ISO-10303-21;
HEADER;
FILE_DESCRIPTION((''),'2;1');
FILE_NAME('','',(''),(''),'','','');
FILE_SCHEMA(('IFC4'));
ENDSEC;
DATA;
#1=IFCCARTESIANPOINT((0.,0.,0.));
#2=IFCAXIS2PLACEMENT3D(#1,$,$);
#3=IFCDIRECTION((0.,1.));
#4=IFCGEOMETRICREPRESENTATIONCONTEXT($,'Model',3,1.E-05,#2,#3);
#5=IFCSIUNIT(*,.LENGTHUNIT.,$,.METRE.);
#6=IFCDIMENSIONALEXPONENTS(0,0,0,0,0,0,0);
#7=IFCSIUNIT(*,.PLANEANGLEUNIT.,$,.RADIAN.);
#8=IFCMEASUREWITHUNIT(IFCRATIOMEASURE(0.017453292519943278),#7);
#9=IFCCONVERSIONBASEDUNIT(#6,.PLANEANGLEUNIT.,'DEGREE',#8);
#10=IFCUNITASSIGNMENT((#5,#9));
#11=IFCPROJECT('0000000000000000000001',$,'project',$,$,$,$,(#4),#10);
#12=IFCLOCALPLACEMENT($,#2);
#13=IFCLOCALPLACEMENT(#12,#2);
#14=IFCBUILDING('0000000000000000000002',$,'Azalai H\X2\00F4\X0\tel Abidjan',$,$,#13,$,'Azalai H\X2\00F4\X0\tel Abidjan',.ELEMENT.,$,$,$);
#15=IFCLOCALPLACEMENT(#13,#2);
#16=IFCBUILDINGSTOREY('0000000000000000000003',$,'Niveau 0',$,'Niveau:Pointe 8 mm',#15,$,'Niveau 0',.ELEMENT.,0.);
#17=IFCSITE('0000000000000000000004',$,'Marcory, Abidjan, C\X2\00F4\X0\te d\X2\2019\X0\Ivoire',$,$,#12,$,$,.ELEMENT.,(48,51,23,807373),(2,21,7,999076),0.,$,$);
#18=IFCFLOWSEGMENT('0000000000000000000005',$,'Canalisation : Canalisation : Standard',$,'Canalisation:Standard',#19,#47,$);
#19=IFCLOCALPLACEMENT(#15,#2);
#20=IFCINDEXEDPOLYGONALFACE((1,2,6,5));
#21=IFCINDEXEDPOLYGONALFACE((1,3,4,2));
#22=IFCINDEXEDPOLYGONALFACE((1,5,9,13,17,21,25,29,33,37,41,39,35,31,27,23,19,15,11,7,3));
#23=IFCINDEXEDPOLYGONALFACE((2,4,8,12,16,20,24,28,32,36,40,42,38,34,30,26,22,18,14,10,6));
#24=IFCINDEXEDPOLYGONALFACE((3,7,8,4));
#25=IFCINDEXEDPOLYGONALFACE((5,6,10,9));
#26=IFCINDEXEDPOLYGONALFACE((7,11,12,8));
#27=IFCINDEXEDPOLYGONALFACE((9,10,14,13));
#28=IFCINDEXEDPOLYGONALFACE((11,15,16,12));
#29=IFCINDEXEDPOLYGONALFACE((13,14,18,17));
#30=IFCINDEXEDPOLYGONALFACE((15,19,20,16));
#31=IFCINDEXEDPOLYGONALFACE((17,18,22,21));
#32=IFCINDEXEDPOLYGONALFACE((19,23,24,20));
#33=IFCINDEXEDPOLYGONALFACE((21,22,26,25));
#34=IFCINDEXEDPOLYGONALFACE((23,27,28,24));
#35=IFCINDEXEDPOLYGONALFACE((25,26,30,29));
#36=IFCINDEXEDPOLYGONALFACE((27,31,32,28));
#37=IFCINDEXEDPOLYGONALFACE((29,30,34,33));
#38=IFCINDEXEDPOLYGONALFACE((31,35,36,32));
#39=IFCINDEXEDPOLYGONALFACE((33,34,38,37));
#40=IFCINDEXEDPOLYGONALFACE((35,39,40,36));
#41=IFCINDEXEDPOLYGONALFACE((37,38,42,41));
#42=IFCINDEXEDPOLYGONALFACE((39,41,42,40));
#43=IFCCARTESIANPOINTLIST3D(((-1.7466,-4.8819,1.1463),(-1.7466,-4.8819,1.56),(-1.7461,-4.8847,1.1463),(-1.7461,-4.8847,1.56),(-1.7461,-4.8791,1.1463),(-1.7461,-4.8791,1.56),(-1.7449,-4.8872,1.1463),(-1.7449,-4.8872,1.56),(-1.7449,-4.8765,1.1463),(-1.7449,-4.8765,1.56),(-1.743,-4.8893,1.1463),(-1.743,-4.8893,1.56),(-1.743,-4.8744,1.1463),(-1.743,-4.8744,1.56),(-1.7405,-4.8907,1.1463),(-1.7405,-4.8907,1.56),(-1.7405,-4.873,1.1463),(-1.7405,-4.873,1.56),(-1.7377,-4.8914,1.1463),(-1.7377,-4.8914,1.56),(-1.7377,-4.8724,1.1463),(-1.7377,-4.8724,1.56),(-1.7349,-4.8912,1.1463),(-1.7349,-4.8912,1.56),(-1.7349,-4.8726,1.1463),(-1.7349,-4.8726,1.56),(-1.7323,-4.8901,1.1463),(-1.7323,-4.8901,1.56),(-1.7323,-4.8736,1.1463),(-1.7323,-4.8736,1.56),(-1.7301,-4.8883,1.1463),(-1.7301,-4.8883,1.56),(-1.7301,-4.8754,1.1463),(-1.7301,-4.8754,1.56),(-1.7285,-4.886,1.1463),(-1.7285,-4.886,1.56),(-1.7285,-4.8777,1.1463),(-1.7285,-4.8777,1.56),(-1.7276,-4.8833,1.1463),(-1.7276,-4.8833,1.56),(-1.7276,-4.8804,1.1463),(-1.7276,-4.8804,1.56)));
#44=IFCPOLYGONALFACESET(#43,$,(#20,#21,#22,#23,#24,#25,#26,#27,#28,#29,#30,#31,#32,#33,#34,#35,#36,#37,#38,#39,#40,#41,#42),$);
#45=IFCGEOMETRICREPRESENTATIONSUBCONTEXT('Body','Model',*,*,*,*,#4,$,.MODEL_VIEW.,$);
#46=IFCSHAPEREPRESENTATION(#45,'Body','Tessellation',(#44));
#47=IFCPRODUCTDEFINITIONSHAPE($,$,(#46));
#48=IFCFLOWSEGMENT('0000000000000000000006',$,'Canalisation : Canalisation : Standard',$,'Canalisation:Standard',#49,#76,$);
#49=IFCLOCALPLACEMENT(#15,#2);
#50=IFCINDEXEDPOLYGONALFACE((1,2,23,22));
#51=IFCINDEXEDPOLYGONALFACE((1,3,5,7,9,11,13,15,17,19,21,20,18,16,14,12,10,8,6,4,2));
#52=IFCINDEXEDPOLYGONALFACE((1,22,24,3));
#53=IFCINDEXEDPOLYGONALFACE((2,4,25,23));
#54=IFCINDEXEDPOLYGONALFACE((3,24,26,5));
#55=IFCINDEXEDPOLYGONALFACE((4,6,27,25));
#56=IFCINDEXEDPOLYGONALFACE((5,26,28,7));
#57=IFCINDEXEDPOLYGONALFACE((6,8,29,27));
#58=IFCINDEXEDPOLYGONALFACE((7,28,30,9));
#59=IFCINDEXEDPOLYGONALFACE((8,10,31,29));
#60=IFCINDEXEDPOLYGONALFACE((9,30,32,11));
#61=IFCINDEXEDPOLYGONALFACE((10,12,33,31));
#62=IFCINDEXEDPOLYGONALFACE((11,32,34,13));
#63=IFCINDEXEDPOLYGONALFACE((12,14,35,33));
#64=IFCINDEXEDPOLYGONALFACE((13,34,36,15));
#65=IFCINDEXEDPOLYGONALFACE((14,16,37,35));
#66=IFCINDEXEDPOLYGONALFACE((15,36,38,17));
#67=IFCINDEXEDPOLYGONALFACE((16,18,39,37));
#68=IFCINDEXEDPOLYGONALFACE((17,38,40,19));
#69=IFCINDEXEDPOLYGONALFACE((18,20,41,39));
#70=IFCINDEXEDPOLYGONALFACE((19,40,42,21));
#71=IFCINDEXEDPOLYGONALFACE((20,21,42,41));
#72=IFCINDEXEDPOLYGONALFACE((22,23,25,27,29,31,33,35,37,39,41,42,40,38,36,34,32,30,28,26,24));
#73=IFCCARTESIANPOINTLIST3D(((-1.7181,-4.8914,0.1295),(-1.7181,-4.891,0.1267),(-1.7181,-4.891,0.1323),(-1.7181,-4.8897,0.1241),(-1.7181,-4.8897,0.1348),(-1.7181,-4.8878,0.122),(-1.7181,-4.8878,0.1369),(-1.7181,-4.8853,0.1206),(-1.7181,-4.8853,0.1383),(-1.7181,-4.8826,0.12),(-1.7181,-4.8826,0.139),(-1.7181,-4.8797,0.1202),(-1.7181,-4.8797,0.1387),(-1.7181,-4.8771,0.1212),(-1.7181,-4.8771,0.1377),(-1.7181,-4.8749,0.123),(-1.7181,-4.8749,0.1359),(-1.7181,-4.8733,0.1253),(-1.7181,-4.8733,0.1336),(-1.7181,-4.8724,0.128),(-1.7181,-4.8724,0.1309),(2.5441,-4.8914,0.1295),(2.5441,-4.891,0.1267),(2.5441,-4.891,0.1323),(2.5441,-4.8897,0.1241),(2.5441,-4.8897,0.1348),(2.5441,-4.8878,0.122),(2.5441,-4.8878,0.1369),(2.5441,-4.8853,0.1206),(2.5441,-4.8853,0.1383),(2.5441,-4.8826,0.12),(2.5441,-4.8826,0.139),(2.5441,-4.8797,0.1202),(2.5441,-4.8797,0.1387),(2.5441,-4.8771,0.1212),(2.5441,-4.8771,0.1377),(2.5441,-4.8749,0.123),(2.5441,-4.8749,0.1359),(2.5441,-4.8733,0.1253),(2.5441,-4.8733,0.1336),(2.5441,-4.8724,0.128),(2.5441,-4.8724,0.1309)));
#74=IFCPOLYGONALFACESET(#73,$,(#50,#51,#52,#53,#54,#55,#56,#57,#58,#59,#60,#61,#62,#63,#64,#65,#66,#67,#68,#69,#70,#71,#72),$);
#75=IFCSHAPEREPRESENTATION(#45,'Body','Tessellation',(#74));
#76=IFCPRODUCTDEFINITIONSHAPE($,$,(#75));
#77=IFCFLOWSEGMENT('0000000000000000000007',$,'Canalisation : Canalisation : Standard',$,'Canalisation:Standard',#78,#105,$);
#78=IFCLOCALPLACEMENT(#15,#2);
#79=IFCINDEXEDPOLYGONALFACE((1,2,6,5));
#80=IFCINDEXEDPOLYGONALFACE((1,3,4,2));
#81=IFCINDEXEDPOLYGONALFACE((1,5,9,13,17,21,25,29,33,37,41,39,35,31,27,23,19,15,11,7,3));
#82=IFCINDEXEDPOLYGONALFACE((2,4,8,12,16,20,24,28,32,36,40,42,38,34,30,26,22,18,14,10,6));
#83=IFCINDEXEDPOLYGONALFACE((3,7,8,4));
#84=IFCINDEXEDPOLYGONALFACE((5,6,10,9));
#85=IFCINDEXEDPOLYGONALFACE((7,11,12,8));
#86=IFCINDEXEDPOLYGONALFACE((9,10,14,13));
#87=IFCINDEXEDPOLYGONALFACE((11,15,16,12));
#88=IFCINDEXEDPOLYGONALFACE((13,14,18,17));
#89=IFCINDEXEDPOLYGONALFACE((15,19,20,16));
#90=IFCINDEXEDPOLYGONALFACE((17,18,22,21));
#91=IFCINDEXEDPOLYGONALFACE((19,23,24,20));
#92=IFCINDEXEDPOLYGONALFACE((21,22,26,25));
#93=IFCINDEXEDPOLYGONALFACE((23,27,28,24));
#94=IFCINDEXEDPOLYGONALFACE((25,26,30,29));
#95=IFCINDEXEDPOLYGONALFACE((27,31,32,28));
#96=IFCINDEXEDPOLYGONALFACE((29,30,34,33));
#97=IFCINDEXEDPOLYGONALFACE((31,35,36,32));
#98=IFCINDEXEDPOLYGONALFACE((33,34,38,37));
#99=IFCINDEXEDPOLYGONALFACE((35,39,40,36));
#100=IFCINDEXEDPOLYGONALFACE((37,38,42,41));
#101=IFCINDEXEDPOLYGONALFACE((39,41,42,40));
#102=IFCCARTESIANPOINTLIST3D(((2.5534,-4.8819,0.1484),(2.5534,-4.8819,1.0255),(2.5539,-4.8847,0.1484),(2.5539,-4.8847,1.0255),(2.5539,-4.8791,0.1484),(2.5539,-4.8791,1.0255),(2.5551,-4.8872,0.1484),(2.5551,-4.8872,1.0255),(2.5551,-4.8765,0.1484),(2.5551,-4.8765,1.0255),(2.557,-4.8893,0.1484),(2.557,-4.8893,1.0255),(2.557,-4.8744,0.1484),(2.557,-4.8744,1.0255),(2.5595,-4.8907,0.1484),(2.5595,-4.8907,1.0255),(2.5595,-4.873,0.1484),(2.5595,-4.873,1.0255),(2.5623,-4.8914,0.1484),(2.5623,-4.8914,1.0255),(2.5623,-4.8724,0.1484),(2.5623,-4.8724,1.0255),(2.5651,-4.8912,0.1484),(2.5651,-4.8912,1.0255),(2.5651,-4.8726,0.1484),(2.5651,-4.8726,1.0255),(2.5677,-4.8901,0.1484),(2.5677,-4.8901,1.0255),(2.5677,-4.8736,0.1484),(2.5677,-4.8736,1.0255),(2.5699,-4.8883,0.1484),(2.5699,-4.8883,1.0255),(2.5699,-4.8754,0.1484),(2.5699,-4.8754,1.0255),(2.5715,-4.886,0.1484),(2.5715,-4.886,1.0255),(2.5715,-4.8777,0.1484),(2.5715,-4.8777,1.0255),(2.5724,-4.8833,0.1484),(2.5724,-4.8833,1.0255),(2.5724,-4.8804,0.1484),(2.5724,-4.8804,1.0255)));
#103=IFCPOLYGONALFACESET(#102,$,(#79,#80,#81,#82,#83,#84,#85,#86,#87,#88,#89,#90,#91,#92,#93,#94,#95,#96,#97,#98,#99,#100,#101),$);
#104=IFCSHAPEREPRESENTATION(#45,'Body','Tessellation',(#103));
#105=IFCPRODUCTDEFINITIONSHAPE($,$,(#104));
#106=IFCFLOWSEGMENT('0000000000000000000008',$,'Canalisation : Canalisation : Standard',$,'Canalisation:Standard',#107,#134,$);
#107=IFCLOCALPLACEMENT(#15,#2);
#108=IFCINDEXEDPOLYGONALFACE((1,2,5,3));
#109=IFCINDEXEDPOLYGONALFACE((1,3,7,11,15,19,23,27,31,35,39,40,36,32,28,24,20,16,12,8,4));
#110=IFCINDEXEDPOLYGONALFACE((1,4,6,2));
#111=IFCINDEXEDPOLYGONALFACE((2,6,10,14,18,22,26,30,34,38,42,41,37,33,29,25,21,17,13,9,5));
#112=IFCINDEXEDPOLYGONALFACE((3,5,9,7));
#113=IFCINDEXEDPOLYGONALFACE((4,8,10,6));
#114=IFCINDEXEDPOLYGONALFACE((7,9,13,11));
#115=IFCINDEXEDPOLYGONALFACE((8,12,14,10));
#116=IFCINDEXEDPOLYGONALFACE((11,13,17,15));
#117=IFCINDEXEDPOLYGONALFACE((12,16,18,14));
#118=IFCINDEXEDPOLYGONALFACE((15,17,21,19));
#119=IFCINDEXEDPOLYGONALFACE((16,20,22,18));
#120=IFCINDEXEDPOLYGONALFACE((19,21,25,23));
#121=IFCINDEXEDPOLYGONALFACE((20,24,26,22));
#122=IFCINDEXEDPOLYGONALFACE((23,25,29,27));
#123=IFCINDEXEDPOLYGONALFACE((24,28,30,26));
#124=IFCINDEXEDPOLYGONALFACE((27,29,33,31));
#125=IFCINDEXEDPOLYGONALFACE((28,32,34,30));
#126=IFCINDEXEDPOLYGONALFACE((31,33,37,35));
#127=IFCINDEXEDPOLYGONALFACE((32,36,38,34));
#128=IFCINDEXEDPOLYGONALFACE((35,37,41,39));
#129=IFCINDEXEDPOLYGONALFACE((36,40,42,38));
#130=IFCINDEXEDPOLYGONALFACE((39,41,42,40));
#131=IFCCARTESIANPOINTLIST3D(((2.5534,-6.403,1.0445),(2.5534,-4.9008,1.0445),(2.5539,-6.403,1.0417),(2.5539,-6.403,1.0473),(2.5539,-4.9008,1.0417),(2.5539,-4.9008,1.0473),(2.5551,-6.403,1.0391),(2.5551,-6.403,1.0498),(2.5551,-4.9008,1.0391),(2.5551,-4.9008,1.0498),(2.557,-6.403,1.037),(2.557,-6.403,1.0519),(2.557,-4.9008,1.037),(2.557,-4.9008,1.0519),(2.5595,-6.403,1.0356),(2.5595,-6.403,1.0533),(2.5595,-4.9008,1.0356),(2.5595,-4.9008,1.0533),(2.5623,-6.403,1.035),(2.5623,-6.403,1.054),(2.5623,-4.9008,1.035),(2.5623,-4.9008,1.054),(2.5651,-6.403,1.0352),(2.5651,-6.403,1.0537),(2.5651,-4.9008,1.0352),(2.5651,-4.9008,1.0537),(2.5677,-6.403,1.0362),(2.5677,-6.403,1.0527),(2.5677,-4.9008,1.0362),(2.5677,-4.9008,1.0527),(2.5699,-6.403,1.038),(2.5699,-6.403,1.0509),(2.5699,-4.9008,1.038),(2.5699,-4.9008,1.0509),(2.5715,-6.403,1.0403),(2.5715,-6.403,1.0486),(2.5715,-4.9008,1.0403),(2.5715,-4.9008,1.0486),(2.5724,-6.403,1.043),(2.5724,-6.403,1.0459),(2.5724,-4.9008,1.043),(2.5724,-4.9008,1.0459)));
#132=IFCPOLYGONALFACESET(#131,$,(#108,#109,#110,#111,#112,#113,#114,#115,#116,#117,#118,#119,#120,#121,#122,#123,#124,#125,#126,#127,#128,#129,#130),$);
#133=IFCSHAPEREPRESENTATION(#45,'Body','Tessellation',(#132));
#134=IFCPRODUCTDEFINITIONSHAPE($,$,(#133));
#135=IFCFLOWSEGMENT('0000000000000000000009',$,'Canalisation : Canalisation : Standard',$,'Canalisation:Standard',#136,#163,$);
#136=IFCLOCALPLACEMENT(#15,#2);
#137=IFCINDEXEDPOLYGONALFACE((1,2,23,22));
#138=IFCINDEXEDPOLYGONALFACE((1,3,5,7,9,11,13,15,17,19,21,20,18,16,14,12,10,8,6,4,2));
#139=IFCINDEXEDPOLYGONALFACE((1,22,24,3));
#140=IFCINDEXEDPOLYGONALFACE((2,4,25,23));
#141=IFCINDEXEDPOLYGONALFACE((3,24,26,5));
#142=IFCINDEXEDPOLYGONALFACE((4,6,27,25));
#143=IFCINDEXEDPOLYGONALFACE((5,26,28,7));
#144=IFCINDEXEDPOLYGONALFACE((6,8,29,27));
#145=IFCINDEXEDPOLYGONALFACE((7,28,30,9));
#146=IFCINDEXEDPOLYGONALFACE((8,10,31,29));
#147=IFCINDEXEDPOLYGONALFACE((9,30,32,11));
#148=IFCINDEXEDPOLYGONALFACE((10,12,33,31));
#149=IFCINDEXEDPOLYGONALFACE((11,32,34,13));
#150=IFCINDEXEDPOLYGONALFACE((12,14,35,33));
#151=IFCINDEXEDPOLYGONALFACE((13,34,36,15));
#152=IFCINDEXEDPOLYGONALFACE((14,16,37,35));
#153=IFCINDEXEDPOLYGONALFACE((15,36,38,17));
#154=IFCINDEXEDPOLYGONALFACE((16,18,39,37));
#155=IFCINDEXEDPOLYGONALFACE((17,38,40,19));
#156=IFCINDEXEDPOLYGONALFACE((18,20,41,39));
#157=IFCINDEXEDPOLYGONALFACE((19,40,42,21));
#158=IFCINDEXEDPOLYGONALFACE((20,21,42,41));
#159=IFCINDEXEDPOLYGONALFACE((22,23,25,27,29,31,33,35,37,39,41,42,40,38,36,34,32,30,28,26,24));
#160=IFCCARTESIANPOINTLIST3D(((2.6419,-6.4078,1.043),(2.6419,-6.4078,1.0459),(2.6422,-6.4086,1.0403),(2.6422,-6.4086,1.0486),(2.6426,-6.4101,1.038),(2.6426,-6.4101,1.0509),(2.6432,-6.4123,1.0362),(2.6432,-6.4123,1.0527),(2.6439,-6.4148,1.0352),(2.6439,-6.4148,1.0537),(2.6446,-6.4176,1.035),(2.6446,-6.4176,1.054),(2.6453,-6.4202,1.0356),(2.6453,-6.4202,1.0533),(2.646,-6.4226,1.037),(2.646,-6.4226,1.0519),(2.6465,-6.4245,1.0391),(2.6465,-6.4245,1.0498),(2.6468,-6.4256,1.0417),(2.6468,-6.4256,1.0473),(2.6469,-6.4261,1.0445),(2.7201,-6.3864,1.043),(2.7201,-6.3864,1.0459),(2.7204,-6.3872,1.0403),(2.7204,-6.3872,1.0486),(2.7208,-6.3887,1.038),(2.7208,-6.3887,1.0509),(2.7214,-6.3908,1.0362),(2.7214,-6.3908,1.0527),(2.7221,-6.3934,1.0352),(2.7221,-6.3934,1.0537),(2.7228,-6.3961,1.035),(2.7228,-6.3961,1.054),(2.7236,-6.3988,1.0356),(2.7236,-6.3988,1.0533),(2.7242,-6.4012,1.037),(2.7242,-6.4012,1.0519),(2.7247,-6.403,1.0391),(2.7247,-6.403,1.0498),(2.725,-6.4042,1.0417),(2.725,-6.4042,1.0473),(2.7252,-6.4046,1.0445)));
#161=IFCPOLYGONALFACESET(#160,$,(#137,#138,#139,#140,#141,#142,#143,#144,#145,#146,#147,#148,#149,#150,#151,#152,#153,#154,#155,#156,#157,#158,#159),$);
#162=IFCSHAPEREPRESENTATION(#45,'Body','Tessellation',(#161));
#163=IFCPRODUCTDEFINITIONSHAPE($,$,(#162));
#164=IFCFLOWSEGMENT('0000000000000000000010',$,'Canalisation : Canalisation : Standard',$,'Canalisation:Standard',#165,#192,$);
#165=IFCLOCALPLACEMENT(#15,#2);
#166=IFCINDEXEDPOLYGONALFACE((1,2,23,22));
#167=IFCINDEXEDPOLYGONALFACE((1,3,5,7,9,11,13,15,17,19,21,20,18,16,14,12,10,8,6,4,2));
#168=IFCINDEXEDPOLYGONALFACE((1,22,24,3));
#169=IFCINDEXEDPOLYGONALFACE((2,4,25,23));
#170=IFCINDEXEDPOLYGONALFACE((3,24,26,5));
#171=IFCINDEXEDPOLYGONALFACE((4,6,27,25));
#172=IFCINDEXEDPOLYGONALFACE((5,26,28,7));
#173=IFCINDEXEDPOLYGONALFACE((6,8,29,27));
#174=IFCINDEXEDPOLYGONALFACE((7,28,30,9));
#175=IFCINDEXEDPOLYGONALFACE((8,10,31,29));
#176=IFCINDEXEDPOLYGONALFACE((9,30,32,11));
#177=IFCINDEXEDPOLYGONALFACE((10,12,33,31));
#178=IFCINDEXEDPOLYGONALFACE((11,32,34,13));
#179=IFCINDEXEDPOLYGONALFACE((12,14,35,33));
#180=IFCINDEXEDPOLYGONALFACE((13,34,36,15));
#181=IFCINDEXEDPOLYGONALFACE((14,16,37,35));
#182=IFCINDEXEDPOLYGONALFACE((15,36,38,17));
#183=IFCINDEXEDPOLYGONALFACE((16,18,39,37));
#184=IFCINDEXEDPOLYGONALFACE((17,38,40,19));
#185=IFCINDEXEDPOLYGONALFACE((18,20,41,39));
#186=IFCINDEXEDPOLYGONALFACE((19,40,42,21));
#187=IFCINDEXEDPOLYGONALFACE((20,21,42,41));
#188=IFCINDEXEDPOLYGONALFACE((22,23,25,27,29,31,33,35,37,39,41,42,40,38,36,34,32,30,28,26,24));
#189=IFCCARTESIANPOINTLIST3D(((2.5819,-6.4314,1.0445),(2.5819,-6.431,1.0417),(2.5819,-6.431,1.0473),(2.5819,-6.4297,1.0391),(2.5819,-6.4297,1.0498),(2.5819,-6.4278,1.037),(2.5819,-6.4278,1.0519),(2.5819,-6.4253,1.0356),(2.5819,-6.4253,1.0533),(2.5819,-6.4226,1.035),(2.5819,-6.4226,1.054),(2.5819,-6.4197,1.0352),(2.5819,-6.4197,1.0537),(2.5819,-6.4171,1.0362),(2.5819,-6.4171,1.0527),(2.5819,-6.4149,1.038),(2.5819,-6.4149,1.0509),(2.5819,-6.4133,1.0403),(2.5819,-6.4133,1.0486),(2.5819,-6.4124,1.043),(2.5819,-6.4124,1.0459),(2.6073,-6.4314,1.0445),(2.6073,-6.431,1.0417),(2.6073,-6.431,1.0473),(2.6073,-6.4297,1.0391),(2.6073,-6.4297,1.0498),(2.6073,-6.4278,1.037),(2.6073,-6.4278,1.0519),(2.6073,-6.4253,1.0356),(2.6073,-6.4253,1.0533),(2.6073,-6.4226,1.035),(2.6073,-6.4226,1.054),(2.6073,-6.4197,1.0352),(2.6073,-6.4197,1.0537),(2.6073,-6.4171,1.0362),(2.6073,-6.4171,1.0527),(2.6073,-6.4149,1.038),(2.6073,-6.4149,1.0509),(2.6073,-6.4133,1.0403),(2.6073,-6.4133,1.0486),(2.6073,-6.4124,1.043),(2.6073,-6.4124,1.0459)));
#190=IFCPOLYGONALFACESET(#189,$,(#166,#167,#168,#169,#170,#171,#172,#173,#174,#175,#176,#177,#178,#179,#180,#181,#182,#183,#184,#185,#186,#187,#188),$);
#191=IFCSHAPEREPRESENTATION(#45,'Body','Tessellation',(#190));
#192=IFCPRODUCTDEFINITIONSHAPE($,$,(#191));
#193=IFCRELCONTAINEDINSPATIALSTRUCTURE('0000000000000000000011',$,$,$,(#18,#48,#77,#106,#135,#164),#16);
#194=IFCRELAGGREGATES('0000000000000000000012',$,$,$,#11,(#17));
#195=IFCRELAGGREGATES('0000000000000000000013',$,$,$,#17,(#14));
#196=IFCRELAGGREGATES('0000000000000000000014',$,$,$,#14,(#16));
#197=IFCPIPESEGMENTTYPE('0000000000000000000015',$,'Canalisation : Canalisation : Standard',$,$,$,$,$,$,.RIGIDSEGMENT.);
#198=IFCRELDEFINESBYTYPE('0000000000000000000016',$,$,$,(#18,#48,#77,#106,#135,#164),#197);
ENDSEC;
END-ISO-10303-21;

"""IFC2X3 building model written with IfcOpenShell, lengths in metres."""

from ifc_helpers import new_model, entity, si_unit, converted_unit, direction, frame, frame_2d, origin, origin_2d_with_axis, place, context, subcontext, project, spatial, circle, extrude, type_object, element, save


model = new_model("IFC2X3")

# Units and contexts
model_context = context("Model", 3, precision=1e-05, world=origin(), true_north=direction((0.0, 1.0)))
body_context = subcontext(model_context, "Body", "Model", "MODEL_VIEW")
ifc_project = project(units=[si_unit("LENGTHUNIT", "METRE"), converted_unit("PLANEANGLEUNIT", "DEGREE", entity("IfcRatioMeasure", 0.017453292519943278), si_unit("PLANEANGLEUNIT", "RADIAN"), dimensions=[0, 0, 0, 0, 0, 0, 0])], contexts=[model_context])

# Site, building, storey
site_placement = place(None, origin())
site = spatial("IfcSite", under=ifc_project, at=site_placement, Name="Marcory, Abidjan, Côte d’Ivoire", CompositionType="ELEMENT", RefLatitude=(48, 51, 23, 807373), RefLongitude=(2, 21, 7, 999076), RefElevation=0.0)
building_placement = place(site_placement, origin())
building = spatial("IfcBuilding", under=site, at=building_placement, Name="Azalai Hôtel Abidjan", LongName="Azalai Hôtel Abidjan", CompositionType="ELEMENT")
storey_placement = place(building_placement, origin())
storey = spatial("IfcBuildingStorey", under=building, at=storey_placement, Name="Niveau 0", ObjectType="Niveau:Pointe 8 mm", LongName="Niveau 0", CompositionType="ELEMENT", Elevation=0.0)

# Flow segments
pipe_segment_type = type_object("IfcPipeSegmentType", Name="Canalisation : Canalisation : Standard", PredefinedType="RIGIDSEGMENT")
flow_segment_1_placement = place(storey_placement, origin())
element("IfcFlowSegment", 1, at=flow_segment_1_placement, inside=storey, type_object=pipe_segment_type, Name="Canalisation : Canalisation : Standard", ObjectType="Canalisation:Standard", context=body_context, shape_type="SweptSolid", body=[
    extrude(circle(Radius=0.0095, at=origin_2d_with_axis()), frame((-1.737, -4.8819, 1.1463), z_axis=(0.0, 0.0, 1.0), x_axis=(-1.0, 0.0, 0.0)), (0.0, 0.0, 1.0), 0.4137),
])
flow_segment_2_placement = place(storey_placement, origin())
element("IfcFlowSegment", 2, at=flow_segment_2_placement, inside=storey, type_object=pipe_segment_type, Name="Canalisation : Canalisation : Standard", ObjectType="Canalisation:Standard", context=body_context, shape_type="SweptSolid", body=[
    extrude(circle(Radius=0.0095, at=frame_2d((0.0, 0.0), x_axis=(1.0, 0.0))), frame((-1.7181, -4.8819, 0.1295), z_axis=(1.0, 0.0, 0.0), x_axis=(0.0, -1.0, 0.0)), (0.0, 0.0, 1.0), 4.2622),
])
flow_segment_3_placement = place(storey_placement, origin())
element("IfcFlowSegment", 3, at=flow_segment_3_placement, inside=storey, type_object=pipe_segment_type, Name="Canalisation : Canalisation : Standard", ObjectType="Canalisation:Standard", context=body_context, shape_type="SweptSolid", body=[
    extrude(circle(Radius=0.0095, at=origin_2d_with_axis()), frame((2.563, -4.8819, 0.1484), z_axis=(0.0, 0.0, 1.0), x_axis=(-1.0, 0.0, 0.0)), (0.0, 0.0, 1.0), 0.8772),
])
flow_segment_4_placement = place(storey_placement, origin())
element("IfcFlowSegment", 4, at=flow_segment_4_placement, inside=storey, type_object=pipe_segment_type, Name="Canalisation : Canalisation : Standard", ObjectType="Canalisation:Standard", context=body_context, shape_type="SweptSolid", body=[
    extrude(circle(Radius=0.0095, at=frame_2d((0.0, 0.0), x_axis=(1.0, 0.0))), frame((2.563, -6.403, 1.0445), z_axis=(0.0, 1.0, 0.0), x_axis=(-1.0, 0.0, 0.0)), (0.0, 0.0, 1.0), 1.5022),
])
flow_segment_5_placement = place(storey_placement, origin())
element("IfcFlowSegment", 5, at=flow_segment_5_placement, inside=storey, type_object=pipe_segment_type, Name="Canalisation : Canalisation : Standard", ObjectType="Canalisation:Standard", context=body_context, shape_type="SweptSolid", body=[
    extrude(circle(Radius=0.0095, at=origin_2d_with_axis()), frame((2.6444, -6.4169, 1.0445), z_axis=(0.964432, 0.264332, 0.0), x_axis=(0.264332, -0.964432, 0.0)), (0.0, 0.0, 1.0), 0.0811),
])
flow_segment_6_placement = place(storey_placement, origin())
element("IfcFlowSegment", 6, at=flow_segment_6_placement, inside=storey, type_object=pipe_segment_type, Name="Canalisation : Canalisation : Standard", ObjectType="Canalisation:Standard", context=body_context, shape_type="SweptSolid", body=[
    extrude(circle(Radius=0.0095, at=origin_2d_with_axis()), frame((2.5819, -6.4219, 1.0445), z_axis=(1.0, 0.0, 0.0), x_axis=(0.0, -1.0, 0.0)), (0.0, 0.0, 1.0), 0.0254),
])

save(model, "model.ifc")
